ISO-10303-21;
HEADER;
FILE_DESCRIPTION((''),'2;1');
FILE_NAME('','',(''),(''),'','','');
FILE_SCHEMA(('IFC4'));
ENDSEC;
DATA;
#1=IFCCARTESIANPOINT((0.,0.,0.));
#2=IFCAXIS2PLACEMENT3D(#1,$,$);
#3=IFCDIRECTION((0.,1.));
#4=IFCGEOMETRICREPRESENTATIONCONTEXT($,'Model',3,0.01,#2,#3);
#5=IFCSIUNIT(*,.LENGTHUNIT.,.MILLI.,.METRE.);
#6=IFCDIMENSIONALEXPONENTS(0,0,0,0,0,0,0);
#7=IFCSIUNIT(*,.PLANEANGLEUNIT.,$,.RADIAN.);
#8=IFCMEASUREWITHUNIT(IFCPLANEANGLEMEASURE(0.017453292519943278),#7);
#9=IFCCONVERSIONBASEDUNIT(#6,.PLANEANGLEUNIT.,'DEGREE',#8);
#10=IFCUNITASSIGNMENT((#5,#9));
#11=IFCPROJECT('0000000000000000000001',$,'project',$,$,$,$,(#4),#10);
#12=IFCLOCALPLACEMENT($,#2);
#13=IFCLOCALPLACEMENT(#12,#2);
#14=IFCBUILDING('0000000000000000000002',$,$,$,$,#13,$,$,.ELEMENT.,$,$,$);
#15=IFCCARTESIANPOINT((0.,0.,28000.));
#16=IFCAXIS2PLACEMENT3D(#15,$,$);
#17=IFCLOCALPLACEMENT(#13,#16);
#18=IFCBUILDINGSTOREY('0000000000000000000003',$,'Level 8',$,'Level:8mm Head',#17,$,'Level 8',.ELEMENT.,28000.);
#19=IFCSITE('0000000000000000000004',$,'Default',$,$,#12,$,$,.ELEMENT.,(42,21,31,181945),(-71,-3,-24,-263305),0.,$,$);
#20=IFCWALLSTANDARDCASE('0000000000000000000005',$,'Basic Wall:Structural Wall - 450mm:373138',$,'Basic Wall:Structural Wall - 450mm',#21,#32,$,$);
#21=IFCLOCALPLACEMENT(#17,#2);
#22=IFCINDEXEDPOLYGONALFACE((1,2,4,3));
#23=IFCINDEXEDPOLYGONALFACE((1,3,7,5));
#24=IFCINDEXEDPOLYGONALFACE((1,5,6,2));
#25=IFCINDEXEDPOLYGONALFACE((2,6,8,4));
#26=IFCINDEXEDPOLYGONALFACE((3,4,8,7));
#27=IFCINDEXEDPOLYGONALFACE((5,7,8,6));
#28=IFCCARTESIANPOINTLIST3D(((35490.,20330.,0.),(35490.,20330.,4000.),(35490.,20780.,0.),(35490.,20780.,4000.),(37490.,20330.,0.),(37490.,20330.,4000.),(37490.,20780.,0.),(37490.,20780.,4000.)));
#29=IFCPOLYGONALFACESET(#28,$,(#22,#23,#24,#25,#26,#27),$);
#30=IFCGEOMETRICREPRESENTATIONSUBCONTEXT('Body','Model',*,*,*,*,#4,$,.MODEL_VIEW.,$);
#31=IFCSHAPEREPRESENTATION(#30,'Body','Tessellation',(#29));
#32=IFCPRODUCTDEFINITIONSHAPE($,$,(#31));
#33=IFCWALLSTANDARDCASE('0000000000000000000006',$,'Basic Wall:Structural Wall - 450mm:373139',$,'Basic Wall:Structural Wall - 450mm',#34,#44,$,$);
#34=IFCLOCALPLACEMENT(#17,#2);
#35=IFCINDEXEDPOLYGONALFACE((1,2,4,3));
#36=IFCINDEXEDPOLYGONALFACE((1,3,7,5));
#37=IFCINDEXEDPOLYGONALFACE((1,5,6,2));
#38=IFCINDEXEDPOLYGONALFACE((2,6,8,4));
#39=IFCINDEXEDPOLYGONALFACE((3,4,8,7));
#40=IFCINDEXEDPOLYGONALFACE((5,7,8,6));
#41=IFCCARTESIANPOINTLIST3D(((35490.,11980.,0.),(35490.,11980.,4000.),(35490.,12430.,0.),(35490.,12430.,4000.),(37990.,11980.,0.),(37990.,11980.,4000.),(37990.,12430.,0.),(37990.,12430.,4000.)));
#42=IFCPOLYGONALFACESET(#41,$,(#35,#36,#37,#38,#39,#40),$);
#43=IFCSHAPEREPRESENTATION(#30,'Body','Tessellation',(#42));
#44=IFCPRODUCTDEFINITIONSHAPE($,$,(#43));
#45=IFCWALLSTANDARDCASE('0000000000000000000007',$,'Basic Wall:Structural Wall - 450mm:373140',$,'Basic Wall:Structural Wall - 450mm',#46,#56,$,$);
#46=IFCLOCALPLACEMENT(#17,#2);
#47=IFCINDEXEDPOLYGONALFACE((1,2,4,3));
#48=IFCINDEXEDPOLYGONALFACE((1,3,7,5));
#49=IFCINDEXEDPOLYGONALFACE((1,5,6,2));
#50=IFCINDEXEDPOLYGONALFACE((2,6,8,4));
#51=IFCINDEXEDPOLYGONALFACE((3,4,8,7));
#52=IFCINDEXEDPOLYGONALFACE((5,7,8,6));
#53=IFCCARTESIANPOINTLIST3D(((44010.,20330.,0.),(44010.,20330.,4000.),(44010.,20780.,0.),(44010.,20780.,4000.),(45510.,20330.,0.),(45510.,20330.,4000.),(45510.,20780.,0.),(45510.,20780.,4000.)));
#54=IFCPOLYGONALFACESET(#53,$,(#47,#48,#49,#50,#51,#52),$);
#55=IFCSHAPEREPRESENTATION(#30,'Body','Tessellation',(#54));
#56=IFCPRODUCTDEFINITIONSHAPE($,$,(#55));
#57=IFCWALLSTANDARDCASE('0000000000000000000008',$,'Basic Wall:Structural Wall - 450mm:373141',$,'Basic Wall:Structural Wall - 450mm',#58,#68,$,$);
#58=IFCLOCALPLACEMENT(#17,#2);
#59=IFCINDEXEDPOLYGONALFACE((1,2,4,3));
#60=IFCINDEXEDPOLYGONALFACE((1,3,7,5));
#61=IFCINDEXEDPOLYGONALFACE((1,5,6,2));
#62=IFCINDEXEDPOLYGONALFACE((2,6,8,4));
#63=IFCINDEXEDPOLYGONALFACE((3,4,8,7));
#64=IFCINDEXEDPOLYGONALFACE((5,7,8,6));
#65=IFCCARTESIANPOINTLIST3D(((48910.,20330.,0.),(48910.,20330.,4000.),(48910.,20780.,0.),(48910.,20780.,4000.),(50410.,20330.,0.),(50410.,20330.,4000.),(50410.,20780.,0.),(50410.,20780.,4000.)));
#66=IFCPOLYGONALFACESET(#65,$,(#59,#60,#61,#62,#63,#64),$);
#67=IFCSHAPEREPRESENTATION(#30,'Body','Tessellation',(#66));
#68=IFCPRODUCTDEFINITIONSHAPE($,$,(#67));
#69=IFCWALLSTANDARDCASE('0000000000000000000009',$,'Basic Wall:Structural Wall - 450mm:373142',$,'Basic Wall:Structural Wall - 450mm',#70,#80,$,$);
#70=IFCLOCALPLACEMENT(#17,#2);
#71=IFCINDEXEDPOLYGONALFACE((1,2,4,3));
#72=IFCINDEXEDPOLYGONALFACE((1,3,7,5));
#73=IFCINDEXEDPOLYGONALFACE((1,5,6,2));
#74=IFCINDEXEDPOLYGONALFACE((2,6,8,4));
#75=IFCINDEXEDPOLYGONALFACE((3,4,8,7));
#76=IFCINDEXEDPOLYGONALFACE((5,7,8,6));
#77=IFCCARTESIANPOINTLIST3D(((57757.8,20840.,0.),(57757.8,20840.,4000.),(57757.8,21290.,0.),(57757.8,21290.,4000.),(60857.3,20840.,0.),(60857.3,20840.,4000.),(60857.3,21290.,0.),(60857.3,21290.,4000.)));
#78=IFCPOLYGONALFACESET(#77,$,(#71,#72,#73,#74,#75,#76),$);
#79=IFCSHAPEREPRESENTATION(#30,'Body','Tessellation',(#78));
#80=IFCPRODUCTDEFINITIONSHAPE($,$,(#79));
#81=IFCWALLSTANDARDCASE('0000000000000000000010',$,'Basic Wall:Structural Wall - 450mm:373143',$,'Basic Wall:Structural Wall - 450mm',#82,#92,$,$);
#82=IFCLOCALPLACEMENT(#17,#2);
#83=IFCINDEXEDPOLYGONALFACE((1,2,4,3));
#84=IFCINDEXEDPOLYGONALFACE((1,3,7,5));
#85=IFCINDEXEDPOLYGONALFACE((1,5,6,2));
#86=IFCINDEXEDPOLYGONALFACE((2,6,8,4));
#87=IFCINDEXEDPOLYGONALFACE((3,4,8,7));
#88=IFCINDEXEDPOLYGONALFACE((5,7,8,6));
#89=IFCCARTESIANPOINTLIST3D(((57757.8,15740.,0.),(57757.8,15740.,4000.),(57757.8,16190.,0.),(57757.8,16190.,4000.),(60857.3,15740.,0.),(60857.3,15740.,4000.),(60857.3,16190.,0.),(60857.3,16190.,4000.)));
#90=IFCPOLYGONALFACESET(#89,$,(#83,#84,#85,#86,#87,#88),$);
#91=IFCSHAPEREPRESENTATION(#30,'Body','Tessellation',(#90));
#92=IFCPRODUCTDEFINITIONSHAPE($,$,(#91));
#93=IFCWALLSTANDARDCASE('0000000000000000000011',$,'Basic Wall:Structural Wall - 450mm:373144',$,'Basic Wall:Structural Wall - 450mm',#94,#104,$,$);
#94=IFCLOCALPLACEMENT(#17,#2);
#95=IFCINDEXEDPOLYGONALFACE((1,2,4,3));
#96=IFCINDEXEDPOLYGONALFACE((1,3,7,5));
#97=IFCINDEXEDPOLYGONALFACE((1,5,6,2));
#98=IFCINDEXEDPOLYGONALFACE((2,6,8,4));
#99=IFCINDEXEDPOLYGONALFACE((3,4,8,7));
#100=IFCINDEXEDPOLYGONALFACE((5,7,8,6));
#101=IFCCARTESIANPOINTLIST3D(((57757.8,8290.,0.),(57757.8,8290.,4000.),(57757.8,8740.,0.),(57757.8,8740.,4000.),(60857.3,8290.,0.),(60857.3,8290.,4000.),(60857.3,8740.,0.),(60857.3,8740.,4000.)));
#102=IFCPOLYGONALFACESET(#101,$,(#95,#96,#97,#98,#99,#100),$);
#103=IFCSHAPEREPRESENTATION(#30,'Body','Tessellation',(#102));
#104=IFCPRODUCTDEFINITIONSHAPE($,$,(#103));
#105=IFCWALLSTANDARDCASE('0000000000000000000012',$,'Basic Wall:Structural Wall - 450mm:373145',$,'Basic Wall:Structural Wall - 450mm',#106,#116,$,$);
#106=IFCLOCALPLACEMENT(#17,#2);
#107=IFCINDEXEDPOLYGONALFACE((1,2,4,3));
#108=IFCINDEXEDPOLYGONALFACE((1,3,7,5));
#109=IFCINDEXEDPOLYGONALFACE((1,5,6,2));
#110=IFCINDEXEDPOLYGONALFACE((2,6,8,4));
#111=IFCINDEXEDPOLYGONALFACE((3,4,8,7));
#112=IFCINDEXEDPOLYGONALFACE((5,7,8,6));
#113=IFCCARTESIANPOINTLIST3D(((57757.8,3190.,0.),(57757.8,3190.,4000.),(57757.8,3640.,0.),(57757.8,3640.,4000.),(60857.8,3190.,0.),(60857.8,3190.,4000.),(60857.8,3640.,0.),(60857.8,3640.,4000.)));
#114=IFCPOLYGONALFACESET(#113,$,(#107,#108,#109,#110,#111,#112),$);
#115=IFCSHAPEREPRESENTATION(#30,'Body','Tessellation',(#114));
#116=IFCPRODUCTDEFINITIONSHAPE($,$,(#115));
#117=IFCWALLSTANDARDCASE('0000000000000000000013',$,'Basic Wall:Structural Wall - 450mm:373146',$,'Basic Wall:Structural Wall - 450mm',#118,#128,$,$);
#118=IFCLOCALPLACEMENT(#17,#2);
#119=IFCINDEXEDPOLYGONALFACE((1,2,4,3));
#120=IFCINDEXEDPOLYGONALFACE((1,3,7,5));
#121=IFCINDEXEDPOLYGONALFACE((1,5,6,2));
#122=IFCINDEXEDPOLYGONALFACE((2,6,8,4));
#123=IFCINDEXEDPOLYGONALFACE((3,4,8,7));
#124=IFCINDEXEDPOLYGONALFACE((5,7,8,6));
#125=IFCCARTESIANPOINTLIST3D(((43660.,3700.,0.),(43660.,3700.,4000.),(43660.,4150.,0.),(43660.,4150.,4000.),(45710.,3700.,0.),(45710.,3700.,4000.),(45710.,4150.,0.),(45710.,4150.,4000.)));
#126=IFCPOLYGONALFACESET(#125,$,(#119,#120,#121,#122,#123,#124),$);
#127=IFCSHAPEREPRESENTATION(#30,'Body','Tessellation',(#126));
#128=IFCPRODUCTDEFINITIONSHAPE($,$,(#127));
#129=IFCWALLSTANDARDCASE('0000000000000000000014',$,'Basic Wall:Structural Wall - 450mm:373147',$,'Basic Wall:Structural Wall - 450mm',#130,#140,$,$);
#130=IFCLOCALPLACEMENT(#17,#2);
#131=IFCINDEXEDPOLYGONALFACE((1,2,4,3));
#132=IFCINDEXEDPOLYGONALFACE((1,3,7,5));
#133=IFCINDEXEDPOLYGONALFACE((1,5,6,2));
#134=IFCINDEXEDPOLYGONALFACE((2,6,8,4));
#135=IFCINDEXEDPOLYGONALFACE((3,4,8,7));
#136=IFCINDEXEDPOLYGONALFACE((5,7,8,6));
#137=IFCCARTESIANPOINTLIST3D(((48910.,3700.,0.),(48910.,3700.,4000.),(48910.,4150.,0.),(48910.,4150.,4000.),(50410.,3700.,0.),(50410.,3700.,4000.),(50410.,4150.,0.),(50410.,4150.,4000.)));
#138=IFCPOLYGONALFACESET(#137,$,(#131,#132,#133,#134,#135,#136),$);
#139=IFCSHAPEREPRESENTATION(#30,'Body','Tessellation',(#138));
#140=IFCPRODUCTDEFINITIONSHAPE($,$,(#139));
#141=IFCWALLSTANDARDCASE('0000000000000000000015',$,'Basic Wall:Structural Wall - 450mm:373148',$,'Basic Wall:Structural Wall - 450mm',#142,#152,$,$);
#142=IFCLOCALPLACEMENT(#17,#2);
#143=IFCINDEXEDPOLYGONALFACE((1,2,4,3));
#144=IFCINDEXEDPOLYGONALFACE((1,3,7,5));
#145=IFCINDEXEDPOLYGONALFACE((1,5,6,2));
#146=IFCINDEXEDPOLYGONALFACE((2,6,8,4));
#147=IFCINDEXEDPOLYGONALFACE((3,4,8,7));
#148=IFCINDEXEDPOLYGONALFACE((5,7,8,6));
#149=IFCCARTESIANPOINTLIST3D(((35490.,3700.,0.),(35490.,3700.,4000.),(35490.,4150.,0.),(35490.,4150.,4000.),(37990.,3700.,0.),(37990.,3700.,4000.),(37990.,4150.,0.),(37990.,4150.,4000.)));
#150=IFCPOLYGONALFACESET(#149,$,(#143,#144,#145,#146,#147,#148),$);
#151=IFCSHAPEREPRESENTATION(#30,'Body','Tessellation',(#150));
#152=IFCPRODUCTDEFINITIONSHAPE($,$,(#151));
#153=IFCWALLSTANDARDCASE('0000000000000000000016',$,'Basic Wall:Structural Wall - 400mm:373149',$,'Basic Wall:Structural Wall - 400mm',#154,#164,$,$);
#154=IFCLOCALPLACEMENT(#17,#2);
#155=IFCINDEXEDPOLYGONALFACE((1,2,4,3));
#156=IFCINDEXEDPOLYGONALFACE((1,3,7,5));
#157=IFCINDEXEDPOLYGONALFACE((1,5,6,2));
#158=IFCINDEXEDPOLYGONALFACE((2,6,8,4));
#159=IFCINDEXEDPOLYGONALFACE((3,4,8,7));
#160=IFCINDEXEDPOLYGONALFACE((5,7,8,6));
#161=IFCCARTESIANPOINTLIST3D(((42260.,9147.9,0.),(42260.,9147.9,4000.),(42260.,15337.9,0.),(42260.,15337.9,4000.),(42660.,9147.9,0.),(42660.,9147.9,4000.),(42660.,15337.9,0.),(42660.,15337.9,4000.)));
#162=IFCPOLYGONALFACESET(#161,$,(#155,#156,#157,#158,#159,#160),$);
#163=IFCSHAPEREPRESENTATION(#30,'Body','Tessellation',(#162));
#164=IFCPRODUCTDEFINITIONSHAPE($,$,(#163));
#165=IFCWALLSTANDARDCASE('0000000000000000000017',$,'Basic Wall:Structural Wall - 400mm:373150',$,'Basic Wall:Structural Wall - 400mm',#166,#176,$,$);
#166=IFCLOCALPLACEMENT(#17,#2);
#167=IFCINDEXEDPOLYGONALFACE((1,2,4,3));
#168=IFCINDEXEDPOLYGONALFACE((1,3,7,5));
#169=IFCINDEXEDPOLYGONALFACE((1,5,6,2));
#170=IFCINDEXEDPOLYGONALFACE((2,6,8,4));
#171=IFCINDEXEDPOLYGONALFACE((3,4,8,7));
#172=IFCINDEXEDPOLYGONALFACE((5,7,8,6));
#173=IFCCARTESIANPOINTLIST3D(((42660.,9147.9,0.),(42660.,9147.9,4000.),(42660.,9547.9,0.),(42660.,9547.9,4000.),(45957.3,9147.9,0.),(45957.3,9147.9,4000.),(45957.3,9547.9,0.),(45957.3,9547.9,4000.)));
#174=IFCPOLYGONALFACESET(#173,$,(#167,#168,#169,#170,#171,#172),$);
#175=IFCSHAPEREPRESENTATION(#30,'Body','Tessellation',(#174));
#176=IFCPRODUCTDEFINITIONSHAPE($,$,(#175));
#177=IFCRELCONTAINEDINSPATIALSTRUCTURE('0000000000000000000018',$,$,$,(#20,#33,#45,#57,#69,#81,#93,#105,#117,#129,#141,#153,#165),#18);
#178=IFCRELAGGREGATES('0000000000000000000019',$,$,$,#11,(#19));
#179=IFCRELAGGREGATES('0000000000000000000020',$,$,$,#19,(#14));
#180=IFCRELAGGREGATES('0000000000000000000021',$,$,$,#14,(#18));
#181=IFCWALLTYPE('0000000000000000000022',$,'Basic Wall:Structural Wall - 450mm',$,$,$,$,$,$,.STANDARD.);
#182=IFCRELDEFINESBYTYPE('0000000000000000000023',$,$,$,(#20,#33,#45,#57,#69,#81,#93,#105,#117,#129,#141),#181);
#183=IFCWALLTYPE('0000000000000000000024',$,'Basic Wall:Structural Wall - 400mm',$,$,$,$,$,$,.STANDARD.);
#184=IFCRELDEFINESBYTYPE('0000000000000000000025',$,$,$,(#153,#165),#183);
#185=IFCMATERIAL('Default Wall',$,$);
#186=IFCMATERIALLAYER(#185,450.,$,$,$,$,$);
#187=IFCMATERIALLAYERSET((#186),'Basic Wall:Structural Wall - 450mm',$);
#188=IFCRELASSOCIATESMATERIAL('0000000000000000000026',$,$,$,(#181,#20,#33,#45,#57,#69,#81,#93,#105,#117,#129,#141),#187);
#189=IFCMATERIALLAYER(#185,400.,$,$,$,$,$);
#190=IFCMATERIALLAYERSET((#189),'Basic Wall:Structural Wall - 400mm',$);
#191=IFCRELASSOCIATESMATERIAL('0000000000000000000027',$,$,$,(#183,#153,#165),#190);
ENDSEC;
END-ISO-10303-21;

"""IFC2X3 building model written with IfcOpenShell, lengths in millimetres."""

from ifc_helpers import new_model, entity, si_unit, converted_unit, direction, frame, frame_2d, origin, place, context, subcontext, project, spatial, rectangle, extrude, material, layer, layer_set, layer_usage, type_object, element, save


model = new_model("IFC2X3")

# Units and contexts
model_context = context("Model", 3, precision=0.01, world=origin(), true_north=direction((0.0, 1.0)))
body_context = subcontext(model_context, "Body", "Model", "MODEL_VIEW")
ifc_project = project(units=[si_unit("LENGTHUNIT", "METRE", prefix="MILLI"), converted_unit("PLANEANGLEUNIT", "DEGREE", entity("IfcPlaneAngleMeasure", 0.017453292519943278), si_unit("PLANEANGLEUNIT", "RADIAN"), dimensions=[0, 0, 0, 0, 0, 0, 0])], contexts=[model_context])

# Site, building, storey
site_placement = place(None, origin())
site = spatial("IfcSite", under=ifc_project, at=site_placement, Name="Default", CompositionType="ELEMENT", RefLatitude=(42, 21, 31, 181945), RefLongitude=(-71, -3, -24, -263305), RefElevation=0.0)
building_placement = place(site_placement, origin())
building = spatial("IfcBuilding", under=site, at=building_placement, CompositionType="ELEMENT")
storey_placement = place(building_placement, frame((0.0, 0.0, 28000.0)))
storey = spatial("IfcBuildingStorey", under=building, at=storey_placement, Name="Level 8", ObjectType="Level:8mm Head", LongName="Level 8", CompositionType="ELEMENT", Elevation=28000.0)

# Walls
ifc_material = material(Name="Default Wall")
ifc_layer_1 = layer(ifc_material, 450.0)
ifc_layer_set_1 = layer_set([ifc_layer_1], Name="Basic Wall:Structural Wall - 450mm")
ifc_layer_usage_1 = layer_usage(ifc_layer_set_1, "AXIS2", "NEGATIVE", 225.0)
wall_type_1 = type_object("IfcWallType", Name="Basic Wall:Structural Wall - 450mm", PredefinedType="STANDARD", material=ifc_layer_set_1)
wall_1_placement = place(storey_placement, frame((35490.0, 20555.0, 0.0)))
element("IfcWallStandardCase", 1, at=wall_1_placement, inside=storey, type_object=wall_type_1, material=ifc_layer_usage_1, Name="Basic Wall:Structural Wall - 450mm:373138", ObjectType="Basic Wall:Structural Wall - 450mm", context=body_context, shape_type="SweptSolid", body=[
    extrude(rectangle(XDim=2000.0, YDim=450.0, at=frame_2d((1000.0, 0.0), x_axis=(-1.0, 0.0))), origin(), (0.0, 0.0, 1.0), 4000.0),
])
ifc_layer_usage_2 = layer_usage(ifc_layer_set_1, "AXIS2", "POSITIVE", -225.0)
wall_2_placement = place(storey_placement, frame((35490.0, 12205.0, 0.0)))
element("IfcWallStandardCase", 2, at=wall_2_placement, inside=storey, type_object=wall_type_1, material=ifc_layer_usage_2, Name="Basic Wall:Structural Wall - 450mm:373139", ObjectType="Basic Wall:Structural Wall - 450mm", context=body_context, shape_type="SweptSolid", body=[
    extrude(rectangle(XDim=2500.0, YDim=450.0, at=frame_2d((1250.0, 0.0), x_axis=(-1.0, 0.0))), origin(), (0.0, 0.0, 1.0), 4000.0),
])
ifc_layer_usage_3 = layer_usage(ifc_layer_set_1, "AXIS2", "NEGATIVE", 225.0)
wall_3_placement = place(storey_placement, frame((44010.0, 20555.0, 0.0)))
element("IfcWallStandardCase", 3, at=wall_3_placement, inside=storey, type_object=wall_type_1, material=ifc_layer_usage_3, Name="Basic Wall:Structural Wall - 450mm:373140", ObjectType="Basic Wall:Structural Wall - 450mm", context=body_context, shape_type="SweptSolid", body=[
    extrude(rectangle(XDim=1500.0, YDim=450.0, at=frame_2d((750.0, 0.0), x_axis=(-1.0, 0.0))), origin(), (0.0, 0.0, 1.0), 4000.0),
])
ifc_layer_usage_4 = layer_usage(ifc_layer_set_1, "AXIS2", "NEGATIVE", 225.0)
wall_4_placement = place(storey_placement, frame((48910.0, 20555.0, 0.0)))
element("IfcWallStandardCase", 4, at=wall_4_placement, inside=storey, type_object=wall_type_1, material=ifc_layer_usage_4, Name="Basic Wall:Structural Wall - 450mm:373141", ObjectType="Basic Wall:Structural Wall - 450mm", context=body_context, shape_type="SweptSolid", body=[
    extrude(rectangle(XDim=1500.0, YDim=450.0, at=frame_2d((750.0, 0.0), x_axis=(-1.0, 0.0))), origin(), (0.0, 0.0, 1.0), 4000.0),
])
ifc_layer_usage_5 = layer_usage(ifc_layer_set_1, "AXIS2", "NEGATIVE", 225.0)
wall_5_placement = place(storey_placement, frame((57757.8, 21065.0, 0.0)))
element("IfcWallStandardCase", 5, at=wall_5_placement, inside=storey, type_object=wall_type_1, material=ifc_layer_usage_5, Name="Basic Wall:Structural Wall - 450mm:373142", ObjectType="Basic Wall:Structural Wall - 450mm", context=body_context, shape_type="SweptSolid", body=[
    extrude(rectangle(XDim=3099.5, YDim=450.0, at=frame_2d((1549.8, 0.0), x_axis=(-1.0, 0.0))), origin(), (0.0, 0.0, 1.0), 4000.0),
])
ifc_layer_usage_6 = layer_usage(ifc_layer_set_1, "AXIS2", "NEGATIVE", 225.0)
wall_6_placement = place(storey_placement, frame((57757.8, 15965.0, 0.0)))
element("IfcWallStandardCase", 6, at=wall_6_placement, inside=storey, type_object=wall_type_1, material=ifc_layer_usage_6, Name="Basic Wall:Structural Wall - 450mm:373143", ObjectType="Basic Wall:Structural Wall - 450mm", context=body_context, shape_type="SweptSolid", body=[
    extrude(rectangle(XDim=3099.5, YDim=450.0, at=frame_2d((1549.8, 0.0), x_axis=(-1.0, 0.0))), origin(), (0.0, 0.0, 1.0), 4000.0),
])
ifc_layer_usage_7 = layer_usage(ifc_layer_set_1, "AXIS2", "POSITIVE", -225.0)
wall_7_placement = place(storey_placement, frame((57757.8, 8515.0, 0.0)))
element("IfcWallStandardCase", 7, at=wall_7_placement, inside=storey, type_object=wall_type_1, material=ifc_layer_usage_7, Name="Basic Wall:Structural Wall - 450mm:373144", ObjectType="Basic Wall:Structural Wall - 450mm", context=body_context, shape_type="SweptSolid", body=[
    extrude(rectangle(XDim=3099.5, YDim=450.0, at=frame_2d((1549.8, 0.0), x_axis=(-1.0, 0.0))), origin(), (0.0, 0.0, 1.0), 4000.0),
])
ifc_layer_usage_8 = layer_usage(ifc_layer_set_1, "AXIS2", "POSITIVE", -225.0)
wall_8_placement = place(storey_placement, frame((57757.8, 3415.0, 0.0)))
element("IfcWallStandardCase", 8, at=wall_8_placement, inside=storey, type_object=wall_type_1, material=ifc_layer_usage_8, Name="Basic Wall:Structural Wall - 450mm:373145", ObjectType="Basic Wall:Structural Wall - 450mm", context=body_context, shape_type="SweptSolid", body=[
    extrude(rectangle(XDim=3100.0, YDim=450.0, at=frame_2d((1550.0, 0.0), x_axis=(-1.0, 0.0))), origin(), (0.0, 0.0, 1.0), 4000.0),
])
ifc_layer_usage_9 = layer_usage(ifc_layer_set_1, "AXIS2", "POSITIVE", -225.0)
wall_9_placement = place(storey_placement, frame((43660.0, 3925.0, 0.0)))
element("IfcWallStandardCase", 9, at=wall_9_placement, inside=storey, type_object=wall_type_1, material=ifc_layer_usage_9, Name="Basic Wall:Structural Wall - 450mm:373146", ObjectType="Basic Wall:Structural Wall - 450mm", context=body_context, shape_type="SweptSolid", body=[
    extrude(rectangle(XDim=2050.0, YDim=450.0, at=frame_2d((1025.0, 0.0), x_axis=(-1.0, 0.0))), origin(), (0.0, 0.0, 1.0), 4000.0),
])
ifc_layer_usage_10 = layer_usage(ifc_layer_set_1, "AXIS2", "POSITIVE", -225.0)
wall_10_placement = place(storey_placement, frame((48910.0, 3925.0, 0.0)))
element("IfcWallStandardCase", 10, at=wall_10_placement, inside=storey, type_object=wall_type_1, material=ifc_layer_usage_10, Name="Basic Wall:Structural Wall - 450mm:373147", ObjectType="Basic Wall:Structural Wall - 450mm", context=body_context, shape_type="SweptSolid", body=[
    extrude(rectangle(XDim=1500.0, YDim=450.0, at=frame_2d((750.0, 0.0), x_axis=(-1.0, 0.0))), origin(), (0.0, 0.0, 1.0), 4000.0),
])
ifc_layer_usage_11 = layer_usage(ifc_layer_set_1, "AXIS2", "POSITIVE", -225.0)
wall_11_placement = place(storey_placement, frame((35490.0, 3925.0, 0.0)))
element("IfcWallStandardCase", 11, at=wall_11_placement, inside=storey, type_object=wall_type_1, material=ifc_layer_usage_11, Name="Basic Wall:Structural Wall - 450mm:373148", ObjectType="Basic Wall:Structural Wall - 450mm", context=body_context, shape_type="SweptSolid", body=[
    extrude(rectangle(XDim=2500.0, YDim=450.0, at=frame_2d((1250.0, 0.0), x_axis=(-1.0, 0.0))), origin(), (0.0, 0.0, 1.0), 4000.0),
])
ifc_layer_2 = layer(ifc_material, 400.0)
ifc_layer_set_2 = layer_set([ifc_layer_2], Name="Basic Wall:Structural Wall - 400mm")
ifc_layer_usage_12 = layer_usage(ifc_layer_set_2, "AXIS2", "POSITIVE", -200.0)
wall_type_2 = type_object("IfcWallType", Name="Basic Wall:Structural Wall - 400mm", PredefinedType="STANDARD", material=ifc_layer_set_2)
wall_12_placement = place(storey_placement, frame((42460.0, 15337.9, 0.0), z_axis=(0.0, 0.0, 1.0), x_axis=(0.0, -1.0, 0.0)))
element("IfcWallStandardCase", 12, at=wall_12_placement, inside=storey, type_object=wall_type_2, material=ifc_layer_usage_12, Name="Basic Wall:Structural Wall - 400mm:373149", ObjectType="Basic Wall:Structural Wall - 400mm", context=body_context, shape_type="SweptSolid", body=[
    extrude(rectangle(XDim=6190.0, YDim=400.0, at=frame_2d((3095.0, 0.0), x_axis=(-1.0, 0.0))), origin(), (0.0, 0.0, 1.0), 4000.0),
])
ifc_layer_usage_13 = layer_usage(ifc_layer_set_2, "AXIS2", "POSITIVE", -200.0)
wall_13_placement = place(storey_placement, frame((42660.0, 9347.9, 0.0)))
element("IfcWallStandardCase", 13, at=wall_13_placement, inside=storey, type_object=wall_type_2, material=ifc_layer_usage_13, Name="Basic Wall:Structural Wall - 400mm:373150", ObjectType="Basic Wall:Structural Wall - 400mm", context=body_context, shape_type="SweptSolid", body=[
    extrude(rectangle(XDim=3297.3, YDim=400.0, at=frame_2d((1648.6, 0.0), x_axis=(-1.0, 0.0))), origin(), (0.0, 0.0, 1.0), 4000.0),
])

save(model, "model.ifc")
